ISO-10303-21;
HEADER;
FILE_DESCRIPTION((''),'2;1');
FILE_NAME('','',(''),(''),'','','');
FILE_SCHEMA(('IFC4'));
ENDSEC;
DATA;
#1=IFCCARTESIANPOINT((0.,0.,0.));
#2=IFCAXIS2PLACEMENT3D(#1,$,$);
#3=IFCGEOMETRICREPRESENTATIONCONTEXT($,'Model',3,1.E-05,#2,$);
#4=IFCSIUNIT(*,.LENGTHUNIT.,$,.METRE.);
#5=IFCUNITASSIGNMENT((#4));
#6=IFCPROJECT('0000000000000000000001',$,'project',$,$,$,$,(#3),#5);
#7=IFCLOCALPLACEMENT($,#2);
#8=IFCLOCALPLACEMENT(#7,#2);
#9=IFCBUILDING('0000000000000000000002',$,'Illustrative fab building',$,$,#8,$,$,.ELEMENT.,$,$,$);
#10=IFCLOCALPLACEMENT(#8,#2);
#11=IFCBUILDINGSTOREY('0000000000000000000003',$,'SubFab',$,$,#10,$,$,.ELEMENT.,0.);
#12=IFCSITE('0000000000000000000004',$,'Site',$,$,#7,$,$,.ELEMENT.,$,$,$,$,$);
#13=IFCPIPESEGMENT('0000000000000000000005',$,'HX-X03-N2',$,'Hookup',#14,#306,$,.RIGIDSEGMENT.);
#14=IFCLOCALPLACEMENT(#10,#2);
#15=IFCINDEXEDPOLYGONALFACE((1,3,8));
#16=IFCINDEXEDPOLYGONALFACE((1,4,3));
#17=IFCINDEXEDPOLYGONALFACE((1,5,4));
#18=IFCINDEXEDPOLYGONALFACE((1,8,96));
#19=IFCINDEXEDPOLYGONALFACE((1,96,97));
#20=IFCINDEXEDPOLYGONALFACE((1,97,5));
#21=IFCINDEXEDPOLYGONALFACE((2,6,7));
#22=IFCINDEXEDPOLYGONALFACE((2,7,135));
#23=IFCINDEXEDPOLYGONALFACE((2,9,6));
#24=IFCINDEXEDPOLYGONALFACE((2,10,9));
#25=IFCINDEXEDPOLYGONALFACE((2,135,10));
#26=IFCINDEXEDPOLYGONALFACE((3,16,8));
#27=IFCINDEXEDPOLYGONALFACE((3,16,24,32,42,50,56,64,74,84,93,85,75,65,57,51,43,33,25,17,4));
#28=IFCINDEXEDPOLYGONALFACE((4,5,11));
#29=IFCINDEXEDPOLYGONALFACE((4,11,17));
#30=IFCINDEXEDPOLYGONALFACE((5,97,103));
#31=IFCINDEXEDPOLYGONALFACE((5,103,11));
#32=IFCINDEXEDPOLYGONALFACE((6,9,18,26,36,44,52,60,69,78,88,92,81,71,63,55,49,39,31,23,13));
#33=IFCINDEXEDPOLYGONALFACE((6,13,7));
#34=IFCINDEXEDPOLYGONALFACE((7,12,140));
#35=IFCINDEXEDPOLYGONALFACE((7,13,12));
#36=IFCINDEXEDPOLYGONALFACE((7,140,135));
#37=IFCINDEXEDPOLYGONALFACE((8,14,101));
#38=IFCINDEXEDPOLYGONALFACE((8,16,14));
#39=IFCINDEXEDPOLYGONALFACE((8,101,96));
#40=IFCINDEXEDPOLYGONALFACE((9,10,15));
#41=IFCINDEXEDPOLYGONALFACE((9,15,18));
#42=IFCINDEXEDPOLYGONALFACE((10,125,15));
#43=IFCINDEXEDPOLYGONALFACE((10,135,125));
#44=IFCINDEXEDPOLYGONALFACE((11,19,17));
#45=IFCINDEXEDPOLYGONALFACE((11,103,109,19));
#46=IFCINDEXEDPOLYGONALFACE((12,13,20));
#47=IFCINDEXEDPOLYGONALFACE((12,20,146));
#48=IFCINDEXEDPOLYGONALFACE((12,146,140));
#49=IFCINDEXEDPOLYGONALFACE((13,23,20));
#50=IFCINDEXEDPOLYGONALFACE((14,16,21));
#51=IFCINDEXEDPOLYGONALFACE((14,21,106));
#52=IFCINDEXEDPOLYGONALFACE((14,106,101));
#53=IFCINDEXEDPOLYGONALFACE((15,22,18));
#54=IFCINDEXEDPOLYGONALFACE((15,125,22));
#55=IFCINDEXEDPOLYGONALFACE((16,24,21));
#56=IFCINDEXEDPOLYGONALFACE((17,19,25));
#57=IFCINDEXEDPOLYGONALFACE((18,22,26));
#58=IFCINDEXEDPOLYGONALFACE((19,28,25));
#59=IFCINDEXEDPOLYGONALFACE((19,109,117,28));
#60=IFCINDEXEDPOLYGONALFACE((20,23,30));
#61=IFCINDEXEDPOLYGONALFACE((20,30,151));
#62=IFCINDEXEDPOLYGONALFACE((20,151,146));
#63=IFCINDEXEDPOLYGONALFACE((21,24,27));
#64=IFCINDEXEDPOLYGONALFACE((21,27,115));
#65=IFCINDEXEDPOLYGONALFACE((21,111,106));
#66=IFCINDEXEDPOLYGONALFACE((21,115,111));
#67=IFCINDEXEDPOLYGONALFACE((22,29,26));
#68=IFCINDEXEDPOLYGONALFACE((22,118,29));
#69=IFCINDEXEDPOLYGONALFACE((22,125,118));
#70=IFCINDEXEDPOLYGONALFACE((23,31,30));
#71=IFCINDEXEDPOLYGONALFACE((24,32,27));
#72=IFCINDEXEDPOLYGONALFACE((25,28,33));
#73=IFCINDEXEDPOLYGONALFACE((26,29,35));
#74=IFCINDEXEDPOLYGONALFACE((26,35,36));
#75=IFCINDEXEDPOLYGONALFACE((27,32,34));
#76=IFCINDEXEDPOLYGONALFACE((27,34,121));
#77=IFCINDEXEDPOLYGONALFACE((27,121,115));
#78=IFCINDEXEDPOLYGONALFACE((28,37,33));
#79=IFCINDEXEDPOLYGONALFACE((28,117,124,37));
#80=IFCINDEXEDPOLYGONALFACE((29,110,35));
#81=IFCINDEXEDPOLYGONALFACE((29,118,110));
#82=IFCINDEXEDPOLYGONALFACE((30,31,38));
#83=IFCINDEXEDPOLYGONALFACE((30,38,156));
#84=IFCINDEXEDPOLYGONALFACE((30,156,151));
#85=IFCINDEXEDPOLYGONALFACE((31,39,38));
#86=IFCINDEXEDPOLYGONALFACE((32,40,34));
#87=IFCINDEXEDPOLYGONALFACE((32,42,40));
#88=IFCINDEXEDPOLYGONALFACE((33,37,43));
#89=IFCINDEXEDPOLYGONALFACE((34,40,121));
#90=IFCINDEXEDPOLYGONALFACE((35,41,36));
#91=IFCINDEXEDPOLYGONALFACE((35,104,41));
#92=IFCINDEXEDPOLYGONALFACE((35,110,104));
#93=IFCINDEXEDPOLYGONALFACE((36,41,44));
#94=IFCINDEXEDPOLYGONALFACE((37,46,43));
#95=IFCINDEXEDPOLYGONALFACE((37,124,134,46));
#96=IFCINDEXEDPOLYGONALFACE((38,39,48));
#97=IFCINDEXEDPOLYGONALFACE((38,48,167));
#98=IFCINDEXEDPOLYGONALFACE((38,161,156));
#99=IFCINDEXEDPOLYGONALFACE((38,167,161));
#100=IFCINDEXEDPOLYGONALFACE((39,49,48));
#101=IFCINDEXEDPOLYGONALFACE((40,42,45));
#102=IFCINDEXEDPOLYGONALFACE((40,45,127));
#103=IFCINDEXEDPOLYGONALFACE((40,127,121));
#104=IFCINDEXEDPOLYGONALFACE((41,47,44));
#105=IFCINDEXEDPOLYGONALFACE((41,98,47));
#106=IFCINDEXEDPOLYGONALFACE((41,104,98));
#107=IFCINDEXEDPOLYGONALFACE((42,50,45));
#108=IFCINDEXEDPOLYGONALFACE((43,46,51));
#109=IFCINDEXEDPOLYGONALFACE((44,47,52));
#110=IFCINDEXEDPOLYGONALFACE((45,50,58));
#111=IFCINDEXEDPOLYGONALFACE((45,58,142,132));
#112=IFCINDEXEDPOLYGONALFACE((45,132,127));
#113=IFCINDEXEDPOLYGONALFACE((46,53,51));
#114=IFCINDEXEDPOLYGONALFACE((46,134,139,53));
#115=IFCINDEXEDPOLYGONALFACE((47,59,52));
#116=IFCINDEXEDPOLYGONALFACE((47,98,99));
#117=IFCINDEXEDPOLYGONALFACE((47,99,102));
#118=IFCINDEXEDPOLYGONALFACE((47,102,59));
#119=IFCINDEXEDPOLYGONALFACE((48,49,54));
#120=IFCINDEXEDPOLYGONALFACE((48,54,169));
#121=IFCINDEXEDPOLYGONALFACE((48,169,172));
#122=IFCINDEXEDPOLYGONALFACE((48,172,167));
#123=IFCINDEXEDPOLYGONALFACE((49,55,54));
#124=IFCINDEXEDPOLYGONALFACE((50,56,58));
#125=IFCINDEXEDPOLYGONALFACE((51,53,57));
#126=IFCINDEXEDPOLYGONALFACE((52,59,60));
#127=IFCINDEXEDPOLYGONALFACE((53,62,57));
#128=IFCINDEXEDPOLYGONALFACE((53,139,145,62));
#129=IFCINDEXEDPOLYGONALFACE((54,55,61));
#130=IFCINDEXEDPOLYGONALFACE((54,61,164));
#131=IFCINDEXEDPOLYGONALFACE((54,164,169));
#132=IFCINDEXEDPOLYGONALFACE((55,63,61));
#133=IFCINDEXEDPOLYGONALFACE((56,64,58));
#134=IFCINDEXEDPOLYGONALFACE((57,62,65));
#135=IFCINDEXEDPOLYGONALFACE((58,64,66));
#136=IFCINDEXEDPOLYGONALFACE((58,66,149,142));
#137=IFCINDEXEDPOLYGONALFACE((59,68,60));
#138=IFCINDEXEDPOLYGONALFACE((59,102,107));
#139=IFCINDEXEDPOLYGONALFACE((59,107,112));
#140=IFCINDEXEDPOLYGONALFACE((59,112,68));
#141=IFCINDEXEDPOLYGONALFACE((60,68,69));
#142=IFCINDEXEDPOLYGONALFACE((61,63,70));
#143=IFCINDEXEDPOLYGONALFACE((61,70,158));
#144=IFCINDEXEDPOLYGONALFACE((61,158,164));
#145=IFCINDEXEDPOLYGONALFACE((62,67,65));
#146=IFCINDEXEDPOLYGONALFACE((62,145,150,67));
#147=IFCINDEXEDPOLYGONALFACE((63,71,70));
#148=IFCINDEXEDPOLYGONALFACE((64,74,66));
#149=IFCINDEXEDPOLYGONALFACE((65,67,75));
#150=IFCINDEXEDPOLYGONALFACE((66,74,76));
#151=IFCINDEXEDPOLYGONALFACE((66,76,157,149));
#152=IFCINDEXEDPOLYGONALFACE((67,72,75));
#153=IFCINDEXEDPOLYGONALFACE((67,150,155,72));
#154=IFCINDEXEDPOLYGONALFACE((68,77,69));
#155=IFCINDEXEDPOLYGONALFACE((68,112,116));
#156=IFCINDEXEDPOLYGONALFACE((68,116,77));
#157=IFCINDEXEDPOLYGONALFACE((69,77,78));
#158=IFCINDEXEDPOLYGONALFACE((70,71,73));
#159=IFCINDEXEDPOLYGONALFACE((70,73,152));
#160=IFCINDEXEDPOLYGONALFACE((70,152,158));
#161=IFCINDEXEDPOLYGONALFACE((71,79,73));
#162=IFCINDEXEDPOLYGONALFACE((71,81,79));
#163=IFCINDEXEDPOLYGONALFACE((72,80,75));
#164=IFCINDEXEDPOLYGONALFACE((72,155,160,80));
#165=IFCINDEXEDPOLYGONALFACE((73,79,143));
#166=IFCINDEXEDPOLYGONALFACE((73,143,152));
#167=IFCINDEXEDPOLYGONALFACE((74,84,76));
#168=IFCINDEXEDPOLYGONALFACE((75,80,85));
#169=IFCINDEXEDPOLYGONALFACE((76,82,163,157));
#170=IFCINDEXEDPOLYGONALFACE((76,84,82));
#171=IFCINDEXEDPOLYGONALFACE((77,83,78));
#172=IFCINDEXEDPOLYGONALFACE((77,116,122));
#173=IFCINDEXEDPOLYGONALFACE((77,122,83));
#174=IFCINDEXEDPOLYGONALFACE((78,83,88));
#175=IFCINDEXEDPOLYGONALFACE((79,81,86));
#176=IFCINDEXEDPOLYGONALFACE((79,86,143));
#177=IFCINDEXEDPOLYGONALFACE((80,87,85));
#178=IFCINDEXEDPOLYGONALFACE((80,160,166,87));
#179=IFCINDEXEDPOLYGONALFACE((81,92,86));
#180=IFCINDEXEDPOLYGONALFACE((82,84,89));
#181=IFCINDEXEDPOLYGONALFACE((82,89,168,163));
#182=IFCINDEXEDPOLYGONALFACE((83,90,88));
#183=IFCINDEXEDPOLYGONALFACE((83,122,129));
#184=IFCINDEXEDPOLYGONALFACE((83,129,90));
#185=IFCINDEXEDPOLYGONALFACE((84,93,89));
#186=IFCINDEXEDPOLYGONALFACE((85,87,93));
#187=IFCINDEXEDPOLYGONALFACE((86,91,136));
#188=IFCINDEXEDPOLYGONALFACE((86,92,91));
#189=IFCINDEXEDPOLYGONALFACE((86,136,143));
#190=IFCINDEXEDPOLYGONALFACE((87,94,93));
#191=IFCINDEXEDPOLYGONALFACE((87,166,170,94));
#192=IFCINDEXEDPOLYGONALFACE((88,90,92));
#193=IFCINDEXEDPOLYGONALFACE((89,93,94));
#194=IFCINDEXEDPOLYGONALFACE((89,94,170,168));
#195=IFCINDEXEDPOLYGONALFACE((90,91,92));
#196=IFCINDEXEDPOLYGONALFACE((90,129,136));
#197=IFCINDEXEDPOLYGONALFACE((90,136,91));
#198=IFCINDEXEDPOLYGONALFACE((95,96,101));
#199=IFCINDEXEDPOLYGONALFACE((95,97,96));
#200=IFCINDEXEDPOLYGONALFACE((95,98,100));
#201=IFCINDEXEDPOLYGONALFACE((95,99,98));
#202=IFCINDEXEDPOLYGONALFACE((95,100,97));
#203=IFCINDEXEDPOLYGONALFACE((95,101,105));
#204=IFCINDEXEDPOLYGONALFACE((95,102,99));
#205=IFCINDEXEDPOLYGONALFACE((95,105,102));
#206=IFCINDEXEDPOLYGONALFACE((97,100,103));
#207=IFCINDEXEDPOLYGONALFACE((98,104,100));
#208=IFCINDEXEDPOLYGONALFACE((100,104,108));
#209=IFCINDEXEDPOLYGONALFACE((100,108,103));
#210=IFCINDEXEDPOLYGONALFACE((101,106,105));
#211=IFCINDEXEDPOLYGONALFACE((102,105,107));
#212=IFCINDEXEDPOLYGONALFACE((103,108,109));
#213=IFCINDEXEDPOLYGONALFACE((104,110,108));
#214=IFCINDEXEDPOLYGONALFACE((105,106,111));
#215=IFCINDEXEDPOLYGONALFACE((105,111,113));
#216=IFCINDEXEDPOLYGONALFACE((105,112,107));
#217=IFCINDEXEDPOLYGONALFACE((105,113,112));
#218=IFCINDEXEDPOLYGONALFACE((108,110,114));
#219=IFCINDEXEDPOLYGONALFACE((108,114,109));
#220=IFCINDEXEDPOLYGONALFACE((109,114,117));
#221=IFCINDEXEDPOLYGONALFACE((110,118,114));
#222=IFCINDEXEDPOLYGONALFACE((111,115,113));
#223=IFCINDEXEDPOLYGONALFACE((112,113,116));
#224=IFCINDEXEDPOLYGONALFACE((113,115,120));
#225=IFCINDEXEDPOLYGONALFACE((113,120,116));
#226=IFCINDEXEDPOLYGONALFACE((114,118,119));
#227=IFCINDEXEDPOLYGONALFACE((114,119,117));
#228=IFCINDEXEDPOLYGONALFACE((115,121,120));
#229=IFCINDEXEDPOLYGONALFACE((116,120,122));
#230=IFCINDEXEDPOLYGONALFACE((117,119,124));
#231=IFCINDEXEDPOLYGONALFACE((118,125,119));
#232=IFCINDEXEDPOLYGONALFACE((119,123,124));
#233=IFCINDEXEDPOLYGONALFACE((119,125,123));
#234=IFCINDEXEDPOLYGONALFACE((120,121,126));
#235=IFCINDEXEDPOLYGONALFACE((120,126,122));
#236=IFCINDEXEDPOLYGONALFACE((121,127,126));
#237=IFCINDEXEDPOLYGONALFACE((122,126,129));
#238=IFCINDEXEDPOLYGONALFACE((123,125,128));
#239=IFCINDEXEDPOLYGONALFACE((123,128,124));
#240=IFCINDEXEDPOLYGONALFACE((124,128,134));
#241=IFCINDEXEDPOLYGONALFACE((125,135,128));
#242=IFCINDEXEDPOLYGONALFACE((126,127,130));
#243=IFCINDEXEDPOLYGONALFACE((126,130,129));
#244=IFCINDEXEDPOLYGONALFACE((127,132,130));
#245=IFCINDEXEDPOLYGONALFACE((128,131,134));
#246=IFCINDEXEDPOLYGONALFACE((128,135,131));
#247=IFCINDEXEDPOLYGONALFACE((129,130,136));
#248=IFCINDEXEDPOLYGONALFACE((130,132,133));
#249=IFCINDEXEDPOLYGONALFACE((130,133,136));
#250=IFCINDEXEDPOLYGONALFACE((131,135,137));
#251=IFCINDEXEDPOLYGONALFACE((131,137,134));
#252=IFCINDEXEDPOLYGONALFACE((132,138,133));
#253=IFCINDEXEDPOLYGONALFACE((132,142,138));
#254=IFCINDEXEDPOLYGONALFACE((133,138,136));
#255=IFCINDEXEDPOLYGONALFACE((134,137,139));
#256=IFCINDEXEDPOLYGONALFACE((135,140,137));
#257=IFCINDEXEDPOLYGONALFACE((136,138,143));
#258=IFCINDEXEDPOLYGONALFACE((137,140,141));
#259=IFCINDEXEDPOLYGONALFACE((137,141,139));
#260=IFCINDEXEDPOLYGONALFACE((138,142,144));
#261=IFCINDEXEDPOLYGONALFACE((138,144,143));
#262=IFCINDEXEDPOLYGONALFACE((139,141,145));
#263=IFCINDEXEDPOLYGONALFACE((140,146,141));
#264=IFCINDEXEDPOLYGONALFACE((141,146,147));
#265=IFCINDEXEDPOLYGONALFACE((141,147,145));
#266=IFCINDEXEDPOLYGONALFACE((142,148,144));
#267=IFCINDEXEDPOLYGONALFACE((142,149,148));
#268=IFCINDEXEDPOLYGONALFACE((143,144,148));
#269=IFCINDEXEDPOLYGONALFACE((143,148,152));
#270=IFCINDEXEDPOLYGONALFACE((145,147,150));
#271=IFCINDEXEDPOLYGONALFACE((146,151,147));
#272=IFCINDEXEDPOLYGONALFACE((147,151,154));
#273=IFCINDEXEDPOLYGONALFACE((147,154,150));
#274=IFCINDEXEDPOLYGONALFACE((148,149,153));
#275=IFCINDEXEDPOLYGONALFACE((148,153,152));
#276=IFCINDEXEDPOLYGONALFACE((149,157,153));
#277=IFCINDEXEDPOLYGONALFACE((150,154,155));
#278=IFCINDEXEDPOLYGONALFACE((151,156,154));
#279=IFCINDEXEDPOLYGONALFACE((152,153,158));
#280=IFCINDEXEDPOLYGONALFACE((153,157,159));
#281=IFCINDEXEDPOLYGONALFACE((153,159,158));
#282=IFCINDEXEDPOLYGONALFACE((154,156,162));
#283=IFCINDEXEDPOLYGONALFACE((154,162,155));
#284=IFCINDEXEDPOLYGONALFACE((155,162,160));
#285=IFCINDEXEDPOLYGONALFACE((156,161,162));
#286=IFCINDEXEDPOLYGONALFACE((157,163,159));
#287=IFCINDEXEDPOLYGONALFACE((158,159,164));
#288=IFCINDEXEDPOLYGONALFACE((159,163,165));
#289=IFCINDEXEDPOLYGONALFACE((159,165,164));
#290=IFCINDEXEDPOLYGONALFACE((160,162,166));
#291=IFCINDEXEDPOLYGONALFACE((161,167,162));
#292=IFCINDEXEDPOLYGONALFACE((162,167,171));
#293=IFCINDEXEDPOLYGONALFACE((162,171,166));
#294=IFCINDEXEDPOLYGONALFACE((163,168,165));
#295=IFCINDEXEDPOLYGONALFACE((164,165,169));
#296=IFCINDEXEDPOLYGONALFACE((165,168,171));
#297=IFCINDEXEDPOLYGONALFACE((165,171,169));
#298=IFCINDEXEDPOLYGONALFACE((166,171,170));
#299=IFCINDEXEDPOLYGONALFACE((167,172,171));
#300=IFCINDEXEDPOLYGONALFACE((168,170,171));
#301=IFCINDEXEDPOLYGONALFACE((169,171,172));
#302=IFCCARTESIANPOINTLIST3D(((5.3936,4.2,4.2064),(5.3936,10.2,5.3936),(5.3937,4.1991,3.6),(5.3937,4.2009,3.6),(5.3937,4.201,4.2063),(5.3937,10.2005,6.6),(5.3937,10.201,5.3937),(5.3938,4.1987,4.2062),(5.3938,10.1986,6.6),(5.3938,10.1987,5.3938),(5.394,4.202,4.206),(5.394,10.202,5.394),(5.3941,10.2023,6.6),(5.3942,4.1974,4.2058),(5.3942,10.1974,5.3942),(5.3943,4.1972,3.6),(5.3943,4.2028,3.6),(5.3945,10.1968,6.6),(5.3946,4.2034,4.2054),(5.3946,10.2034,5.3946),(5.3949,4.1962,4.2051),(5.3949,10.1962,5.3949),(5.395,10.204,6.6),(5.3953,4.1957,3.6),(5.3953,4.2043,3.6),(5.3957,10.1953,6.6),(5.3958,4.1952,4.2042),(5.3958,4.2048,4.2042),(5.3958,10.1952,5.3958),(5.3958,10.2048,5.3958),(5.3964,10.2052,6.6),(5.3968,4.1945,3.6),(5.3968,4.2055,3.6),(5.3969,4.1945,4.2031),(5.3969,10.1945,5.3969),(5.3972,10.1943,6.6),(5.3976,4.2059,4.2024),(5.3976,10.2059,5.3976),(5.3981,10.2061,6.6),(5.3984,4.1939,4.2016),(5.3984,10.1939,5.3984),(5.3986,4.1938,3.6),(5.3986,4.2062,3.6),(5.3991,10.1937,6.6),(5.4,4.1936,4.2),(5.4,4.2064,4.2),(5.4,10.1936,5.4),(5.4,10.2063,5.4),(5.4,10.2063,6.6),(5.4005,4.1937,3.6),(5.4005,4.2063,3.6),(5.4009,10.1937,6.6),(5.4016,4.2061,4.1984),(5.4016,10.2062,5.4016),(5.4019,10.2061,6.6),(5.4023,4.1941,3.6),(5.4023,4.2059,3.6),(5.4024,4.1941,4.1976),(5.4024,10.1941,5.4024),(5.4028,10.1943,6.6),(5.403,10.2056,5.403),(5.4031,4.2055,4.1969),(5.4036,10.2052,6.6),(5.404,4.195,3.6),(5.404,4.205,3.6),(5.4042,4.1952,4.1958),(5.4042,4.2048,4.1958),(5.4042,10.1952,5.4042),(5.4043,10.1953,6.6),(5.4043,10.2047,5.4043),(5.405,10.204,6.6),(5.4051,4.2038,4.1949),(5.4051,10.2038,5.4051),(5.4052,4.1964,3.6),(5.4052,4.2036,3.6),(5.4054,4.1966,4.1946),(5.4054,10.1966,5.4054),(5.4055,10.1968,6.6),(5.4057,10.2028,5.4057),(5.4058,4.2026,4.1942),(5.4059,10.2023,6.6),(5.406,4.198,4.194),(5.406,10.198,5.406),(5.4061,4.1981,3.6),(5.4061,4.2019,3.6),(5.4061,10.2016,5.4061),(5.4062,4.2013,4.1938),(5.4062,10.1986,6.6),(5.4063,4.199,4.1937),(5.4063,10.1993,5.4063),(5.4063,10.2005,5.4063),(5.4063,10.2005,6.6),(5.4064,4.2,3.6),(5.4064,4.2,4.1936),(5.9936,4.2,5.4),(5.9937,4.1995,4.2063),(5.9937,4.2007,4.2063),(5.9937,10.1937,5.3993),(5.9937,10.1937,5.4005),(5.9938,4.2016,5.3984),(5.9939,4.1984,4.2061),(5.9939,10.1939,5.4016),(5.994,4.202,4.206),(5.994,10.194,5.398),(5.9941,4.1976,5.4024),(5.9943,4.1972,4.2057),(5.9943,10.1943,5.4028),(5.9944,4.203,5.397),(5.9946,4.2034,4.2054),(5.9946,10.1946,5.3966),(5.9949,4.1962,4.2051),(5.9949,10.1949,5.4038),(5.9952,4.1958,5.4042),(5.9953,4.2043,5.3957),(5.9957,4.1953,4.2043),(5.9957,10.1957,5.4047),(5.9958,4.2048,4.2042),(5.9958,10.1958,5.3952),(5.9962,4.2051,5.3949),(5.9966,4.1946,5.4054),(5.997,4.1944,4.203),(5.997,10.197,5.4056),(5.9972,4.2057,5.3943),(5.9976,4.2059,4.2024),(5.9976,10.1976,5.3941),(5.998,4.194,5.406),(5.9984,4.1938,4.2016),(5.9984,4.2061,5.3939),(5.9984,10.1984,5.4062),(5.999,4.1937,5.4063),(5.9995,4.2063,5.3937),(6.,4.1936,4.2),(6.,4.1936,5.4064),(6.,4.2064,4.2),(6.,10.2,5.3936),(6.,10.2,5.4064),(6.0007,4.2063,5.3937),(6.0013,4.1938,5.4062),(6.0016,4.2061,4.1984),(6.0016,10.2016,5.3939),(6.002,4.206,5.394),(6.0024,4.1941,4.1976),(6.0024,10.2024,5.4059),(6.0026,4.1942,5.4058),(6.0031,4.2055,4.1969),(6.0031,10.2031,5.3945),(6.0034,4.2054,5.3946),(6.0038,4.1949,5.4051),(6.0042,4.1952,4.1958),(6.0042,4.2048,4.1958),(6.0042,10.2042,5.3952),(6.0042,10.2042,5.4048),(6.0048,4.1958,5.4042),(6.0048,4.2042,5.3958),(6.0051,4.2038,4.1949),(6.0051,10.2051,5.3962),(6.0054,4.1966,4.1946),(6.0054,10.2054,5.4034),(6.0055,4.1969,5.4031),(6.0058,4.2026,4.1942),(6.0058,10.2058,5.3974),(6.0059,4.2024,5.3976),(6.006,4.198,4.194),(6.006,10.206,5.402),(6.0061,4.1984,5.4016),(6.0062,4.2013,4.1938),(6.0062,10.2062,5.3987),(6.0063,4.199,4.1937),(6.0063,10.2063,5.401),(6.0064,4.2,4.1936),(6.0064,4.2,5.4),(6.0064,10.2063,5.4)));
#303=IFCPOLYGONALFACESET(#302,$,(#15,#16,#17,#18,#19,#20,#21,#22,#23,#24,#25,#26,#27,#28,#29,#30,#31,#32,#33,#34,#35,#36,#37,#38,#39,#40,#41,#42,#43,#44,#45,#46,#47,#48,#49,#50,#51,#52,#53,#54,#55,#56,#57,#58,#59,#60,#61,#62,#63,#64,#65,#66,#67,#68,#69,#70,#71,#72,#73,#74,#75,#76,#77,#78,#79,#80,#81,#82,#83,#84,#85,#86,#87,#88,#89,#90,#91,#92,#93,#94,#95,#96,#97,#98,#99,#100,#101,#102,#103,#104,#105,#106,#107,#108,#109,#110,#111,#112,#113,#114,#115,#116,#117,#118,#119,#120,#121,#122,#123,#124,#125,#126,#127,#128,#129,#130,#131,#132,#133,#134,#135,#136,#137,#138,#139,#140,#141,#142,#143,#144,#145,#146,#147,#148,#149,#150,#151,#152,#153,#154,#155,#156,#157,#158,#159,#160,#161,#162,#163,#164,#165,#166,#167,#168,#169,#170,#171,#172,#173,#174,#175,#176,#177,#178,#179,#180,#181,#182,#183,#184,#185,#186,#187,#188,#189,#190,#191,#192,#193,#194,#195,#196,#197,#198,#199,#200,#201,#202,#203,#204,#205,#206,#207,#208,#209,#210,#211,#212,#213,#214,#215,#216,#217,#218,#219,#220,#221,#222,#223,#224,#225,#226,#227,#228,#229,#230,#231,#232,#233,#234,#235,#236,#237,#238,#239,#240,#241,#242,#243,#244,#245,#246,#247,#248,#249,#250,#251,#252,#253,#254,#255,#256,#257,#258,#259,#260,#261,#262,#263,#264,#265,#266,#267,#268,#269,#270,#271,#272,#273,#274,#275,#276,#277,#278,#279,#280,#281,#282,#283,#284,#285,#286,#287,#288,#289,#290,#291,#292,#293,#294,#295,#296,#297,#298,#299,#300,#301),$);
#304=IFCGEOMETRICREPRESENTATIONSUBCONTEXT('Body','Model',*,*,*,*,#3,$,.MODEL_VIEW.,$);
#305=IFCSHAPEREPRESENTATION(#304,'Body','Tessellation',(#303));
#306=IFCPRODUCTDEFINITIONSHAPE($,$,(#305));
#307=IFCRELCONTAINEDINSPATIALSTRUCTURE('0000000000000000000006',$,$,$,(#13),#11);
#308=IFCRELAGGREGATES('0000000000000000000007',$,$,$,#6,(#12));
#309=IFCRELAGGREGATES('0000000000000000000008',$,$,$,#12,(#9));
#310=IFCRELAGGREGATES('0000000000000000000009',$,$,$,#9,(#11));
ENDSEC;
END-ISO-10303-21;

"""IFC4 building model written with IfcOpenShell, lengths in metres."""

from ifc_helpers import new_model, entity, si_unit, origin, place, context, subcontext, project, spatial, element, save


model = new_model("IFC4")

# Units and contexts
model_context = context("Model", 3, precision=1e-05, world=origin())
body_context = subcontext(model_context, "Body", "Model", "MODEL_VIEW")
ifc_project = project(units=[si_unit("LENGTHUNIT", "METRE")], contexts=[model_context])

# Site, building, storey
site_placement = place(None, origin())
site = spatial("IfcSite", under=ifc_project, at=site_placement, Name="Site", CompositionType="ELEMENT")
building_placement = place(site_placement, origin())
building = spatial("IfcBuilding", under=site, at=building_placement, Name="Illustrative fab building", CompositionType="ELEMENT")
storey_placement = place(building_placement, origin())
storey = spatial("IfcBuildingStorey", under=building, at=storey_placement, Name="SubFab", CompositionType="ELEMENT", Elevation=0.0)

# Pipe segment
pipe_segment_1_placement = place(storey_placement, origin())
element("IfcPipeSegment", 1, at=pipe_segment_1_placement, inside=storey, Name="HX-X03-N2", ObjectType="Hookup", PredefinedType="RIGIDSEGMENT", context=body_context, shape_type="AdvancedSweptSolid", body=[
    entity("IfcSweptDiskSolid", entity("IfcPolyline", [entity("IfcCartesianPoint", [5.4, 4.2, 3.6]), entity("IfcCartesianPoint", [5.4, 4.2, 4.2]), entity("IfcCartesianPoint", [6.0, 4.2, 4.2]), entity("IfcCartesianPoint", [6.0, 4.2, 5.4]), entity("IfcCartesianPoint", [6.0, 10.2, 5.4]), entity("IfcCartesianPoint", [5.4, 10.2, 5.4]), entity("IfcCartesianPoint", [5.4, 10.2, 6.6])]), 0.0063),
])

save(model, "model.ifc")
